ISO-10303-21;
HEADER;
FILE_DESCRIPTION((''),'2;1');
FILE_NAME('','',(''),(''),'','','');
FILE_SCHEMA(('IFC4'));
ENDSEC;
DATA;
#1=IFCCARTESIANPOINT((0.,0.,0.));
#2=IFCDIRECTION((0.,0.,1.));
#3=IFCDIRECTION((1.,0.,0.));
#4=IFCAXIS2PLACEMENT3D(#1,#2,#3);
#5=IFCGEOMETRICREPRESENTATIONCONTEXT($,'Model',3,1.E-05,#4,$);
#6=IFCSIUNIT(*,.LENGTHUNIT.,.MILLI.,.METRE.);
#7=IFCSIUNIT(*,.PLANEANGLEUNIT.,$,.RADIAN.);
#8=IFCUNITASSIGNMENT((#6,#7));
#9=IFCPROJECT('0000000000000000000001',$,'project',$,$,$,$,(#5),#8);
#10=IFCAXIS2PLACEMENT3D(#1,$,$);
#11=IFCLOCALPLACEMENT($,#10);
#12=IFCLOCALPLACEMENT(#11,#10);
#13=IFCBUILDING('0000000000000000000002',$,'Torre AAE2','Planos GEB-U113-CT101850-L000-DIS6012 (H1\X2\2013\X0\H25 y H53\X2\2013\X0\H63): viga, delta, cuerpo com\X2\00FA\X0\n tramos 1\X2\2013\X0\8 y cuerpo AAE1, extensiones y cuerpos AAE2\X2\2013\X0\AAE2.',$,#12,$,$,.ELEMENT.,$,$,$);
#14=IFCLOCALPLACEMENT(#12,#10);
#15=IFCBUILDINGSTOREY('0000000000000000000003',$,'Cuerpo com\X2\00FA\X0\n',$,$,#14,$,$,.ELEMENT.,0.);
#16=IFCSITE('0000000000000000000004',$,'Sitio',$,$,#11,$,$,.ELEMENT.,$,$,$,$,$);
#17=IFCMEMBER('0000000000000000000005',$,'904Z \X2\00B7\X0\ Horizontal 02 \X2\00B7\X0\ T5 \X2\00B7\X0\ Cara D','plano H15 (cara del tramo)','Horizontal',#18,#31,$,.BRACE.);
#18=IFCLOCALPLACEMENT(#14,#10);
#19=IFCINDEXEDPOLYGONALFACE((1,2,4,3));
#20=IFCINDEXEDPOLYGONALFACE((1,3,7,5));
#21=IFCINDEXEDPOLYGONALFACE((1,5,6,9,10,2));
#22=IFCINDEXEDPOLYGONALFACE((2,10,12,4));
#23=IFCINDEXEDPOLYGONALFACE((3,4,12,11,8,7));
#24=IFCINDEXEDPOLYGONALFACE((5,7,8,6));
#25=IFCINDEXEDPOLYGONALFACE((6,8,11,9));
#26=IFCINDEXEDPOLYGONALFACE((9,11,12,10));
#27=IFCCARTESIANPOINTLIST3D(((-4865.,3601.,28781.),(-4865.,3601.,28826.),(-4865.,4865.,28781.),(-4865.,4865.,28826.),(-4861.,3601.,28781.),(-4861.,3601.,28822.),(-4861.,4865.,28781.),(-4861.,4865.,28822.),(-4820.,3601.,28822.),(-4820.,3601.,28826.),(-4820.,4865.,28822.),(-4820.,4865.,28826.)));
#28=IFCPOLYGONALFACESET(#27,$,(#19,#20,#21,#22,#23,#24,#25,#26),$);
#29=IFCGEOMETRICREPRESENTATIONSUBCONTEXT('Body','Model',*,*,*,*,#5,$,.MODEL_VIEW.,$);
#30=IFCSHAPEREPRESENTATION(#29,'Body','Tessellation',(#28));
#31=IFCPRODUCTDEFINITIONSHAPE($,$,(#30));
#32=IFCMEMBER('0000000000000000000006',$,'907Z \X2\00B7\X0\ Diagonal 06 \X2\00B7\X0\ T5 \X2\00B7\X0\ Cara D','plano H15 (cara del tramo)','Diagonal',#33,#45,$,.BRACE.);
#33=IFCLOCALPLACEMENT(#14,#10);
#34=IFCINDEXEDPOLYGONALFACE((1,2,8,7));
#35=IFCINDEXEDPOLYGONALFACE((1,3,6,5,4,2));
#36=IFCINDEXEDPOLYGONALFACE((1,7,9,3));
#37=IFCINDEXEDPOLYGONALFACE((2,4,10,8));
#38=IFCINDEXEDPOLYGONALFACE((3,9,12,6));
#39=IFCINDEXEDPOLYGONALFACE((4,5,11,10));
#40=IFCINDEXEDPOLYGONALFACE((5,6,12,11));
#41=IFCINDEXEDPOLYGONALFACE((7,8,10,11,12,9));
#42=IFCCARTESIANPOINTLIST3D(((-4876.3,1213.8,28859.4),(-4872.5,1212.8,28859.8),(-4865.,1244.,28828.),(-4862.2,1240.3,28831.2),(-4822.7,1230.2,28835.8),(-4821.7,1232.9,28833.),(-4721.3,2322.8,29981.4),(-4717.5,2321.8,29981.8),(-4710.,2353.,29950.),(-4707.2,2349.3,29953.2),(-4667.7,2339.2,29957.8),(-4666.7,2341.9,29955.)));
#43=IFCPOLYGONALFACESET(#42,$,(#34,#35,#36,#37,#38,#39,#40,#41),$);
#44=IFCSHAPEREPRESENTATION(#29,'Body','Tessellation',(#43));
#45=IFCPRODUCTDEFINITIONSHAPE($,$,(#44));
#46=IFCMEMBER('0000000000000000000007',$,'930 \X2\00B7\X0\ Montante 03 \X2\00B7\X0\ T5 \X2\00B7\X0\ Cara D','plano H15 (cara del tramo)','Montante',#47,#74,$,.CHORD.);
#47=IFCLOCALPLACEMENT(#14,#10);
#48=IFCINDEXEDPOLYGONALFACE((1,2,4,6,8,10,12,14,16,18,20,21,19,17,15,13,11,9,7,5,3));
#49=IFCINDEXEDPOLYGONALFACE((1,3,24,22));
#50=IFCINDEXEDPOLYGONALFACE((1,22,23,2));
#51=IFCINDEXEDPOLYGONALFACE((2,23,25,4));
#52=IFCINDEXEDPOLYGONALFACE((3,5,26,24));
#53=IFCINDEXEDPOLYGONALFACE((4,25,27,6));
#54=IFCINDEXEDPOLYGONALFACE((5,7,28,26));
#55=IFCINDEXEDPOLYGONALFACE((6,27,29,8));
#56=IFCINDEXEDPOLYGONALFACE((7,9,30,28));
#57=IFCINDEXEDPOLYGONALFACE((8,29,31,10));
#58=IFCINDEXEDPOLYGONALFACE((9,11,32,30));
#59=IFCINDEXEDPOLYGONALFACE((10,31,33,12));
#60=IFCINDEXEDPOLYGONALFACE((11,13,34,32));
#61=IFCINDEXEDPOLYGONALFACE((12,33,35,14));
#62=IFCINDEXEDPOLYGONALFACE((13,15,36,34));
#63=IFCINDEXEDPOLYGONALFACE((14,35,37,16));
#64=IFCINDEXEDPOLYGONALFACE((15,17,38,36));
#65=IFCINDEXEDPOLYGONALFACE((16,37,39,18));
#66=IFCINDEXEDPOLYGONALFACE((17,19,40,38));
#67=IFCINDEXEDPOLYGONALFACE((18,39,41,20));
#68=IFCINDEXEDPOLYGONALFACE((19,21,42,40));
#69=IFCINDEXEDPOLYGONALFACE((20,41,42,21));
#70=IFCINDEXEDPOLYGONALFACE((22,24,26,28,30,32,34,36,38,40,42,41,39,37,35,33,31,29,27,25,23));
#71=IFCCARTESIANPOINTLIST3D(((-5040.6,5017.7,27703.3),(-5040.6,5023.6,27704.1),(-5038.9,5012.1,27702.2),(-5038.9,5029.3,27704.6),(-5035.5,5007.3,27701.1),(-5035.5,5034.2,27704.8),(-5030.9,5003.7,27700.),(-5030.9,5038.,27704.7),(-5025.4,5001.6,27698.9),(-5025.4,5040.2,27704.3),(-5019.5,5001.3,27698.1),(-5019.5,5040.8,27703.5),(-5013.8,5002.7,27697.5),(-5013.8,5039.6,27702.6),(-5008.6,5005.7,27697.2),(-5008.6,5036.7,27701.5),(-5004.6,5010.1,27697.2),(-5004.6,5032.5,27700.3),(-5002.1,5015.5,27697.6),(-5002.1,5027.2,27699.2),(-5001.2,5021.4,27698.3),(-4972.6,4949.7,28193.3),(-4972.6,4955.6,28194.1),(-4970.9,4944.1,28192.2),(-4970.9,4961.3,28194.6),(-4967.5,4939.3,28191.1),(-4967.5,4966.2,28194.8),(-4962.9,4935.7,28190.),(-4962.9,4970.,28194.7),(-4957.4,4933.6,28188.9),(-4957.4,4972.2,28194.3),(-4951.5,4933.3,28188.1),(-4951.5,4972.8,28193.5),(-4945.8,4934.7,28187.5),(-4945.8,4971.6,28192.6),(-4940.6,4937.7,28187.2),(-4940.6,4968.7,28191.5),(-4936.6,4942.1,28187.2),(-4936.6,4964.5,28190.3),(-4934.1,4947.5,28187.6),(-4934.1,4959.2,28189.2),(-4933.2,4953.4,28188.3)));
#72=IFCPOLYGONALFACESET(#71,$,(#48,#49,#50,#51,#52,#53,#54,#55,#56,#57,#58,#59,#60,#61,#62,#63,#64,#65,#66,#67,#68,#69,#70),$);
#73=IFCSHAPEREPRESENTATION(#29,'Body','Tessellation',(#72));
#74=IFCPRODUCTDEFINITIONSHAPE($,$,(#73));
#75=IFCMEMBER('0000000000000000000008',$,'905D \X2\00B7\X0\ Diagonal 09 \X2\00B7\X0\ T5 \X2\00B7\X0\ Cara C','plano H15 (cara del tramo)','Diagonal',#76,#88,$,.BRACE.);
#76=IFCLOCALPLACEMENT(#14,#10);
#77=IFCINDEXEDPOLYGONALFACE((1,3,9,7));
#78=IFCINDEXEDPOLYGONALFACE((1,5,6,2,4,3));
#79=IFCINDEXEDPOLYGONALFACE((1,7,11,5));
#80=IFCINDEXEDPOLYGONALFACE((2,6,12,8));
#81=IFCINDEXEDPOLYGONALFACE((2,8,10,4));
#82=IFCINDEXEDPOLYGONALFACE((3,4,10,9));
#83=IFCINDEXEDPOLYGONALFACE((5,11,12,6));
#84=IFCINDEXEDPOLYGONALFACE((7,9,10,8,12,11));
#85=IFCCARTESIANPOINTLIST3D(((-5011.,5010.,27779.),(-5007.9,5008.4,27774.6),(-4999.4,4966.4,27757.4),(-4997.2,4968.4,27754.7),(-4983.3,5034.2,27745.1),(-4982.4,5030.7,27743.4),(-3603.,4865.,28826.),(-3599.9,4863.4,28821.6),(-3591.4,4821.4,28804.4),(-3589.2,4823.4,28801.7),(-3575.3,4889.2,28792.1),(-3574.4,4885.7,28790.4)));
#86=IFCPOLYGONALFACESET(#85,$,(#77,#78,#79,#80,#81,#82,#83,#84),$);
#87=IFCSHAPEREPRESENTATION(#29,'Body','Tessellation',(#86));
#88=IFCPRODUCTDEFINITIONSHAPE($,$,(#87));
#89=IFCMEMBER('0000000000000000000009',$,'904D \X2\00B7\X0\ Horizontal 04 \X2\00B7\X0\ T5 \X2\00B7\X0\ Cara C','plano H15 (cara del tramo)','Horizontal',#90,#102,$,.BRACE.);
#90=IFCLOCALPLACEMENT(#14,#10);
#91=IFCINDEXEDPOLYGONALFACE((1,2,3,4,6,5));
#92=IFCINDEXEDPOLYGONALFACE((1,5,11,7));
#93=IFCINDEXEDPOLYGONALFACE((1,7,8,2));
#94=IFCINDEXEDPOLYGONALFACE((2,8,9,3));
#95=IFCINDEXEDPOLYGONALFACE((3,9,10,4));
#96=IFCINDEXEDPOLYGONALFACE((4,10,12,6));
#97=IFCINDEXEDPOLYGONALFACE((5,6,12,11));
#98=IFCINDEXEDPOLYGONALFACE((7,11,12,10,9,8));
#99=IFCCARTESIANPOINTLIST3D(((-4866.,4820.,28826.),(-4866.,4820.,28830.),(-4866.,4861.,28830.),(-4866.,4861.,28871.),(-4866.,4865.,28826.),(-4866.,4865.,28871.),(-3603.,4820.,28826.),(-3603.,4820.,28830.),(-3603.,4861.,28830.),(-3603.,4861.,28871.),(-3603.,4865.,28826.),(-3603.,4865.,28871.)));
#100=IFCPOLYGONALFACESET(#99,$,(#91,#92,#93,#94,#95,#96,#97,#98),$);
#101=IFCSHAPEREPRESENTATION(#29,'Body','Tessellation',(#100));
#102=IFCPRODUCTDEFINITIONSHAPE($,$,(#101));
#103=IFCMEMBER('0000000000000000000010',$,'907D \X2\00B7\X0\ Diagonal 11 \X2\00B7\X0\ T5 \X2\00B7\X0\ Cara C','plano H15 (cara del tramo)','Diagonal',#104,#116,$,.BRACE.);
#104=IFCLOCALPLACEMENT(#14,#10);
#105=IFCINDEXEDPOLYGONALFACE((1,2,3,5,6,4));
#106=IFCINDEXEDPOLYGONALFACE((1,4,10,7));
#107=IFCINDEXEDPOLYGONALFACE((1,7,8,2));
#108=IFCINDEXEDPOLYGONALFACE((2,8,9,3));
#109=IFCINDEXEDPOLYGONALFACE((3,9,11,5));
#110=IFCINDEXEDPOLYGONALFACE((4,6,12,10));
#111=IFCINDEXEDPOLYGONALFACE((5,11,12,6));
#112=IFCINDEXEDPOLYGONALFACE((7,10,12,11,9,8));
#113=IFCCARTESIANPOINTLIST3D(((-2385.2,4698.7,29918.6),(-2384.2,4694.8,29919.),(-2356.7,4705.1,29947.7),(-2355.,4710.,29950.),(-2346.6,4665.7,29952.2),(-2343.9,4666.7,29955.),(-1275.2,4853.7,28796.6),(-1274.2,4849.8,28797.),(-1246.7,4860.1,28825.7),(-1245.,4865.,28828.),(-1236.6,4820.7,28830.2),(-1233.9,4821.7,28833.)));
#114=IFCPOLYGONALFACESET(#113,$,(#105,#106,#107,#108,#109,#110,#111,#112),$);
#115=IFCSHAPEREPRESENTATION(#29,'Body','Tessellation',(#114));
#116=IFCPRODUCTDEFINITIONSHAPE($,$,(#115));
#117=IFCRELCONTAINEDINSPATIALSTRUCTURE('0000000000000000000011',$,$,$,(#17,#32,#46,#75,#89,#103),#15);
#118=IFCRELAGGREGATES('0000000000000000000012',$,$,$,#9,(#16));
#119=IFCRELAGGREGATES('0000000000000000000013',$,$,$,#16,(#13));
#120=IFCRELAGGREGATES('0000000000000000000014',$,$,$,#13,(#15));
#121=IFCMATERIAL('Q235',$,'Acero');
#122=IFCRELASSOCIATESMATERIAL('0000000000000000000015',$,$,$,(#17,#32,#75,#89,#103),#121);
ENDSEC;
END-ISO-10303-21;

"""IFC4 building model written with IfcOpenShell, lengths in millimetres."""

from ifc_helpers import new_model, si_unit, frame, frame_2d, origin, origin_with_axes, place, context, subcontext, project, spatial, circle, l_section, extrude, material, element, save


model = new_model("IFC4")

# Units and contexts
model_context = context("Model", 3, precision=1e-05, world=origin_with_axes())
body_context = subcontext(model_context, "Body", "Model", "MODEL_VIEW")
ifc_project = project(units=[si_unit("LENGTHUNIT", "METRE", prefix="MILLI"), si_unit("PLANEANGLEUNIT", "RADIAN")], contexts=[model_context])

# Site, building, storey
site_placement = place(None, origin())
site = spatial("IfcSite", under=ifc_project, at=site_placement, Name="Sitio", CompositionType="ELEMENT")
building_placement = place(site_placement, origin())
building = spatial("IfcBuilding", under=site, at=building_placement, Name="Torre AAE2", Description="Planos GEB-U113-CT101850-L000-DIS6012 (H1–H25 y H53–H63): viga, delta, cuerpo común tramos 1–8 y cuerpo AAE1, extensiones y cuerpos AAE2–AAE2.", CompositionType="ELEMENT")
storey_placement = place(building_placement, origin())
storey = spatial("IfcBuildingStorey", under=building, at=storey_placement, Name="Cuerpo común", CompositionType="ELEMENT", Elevation=0.0)

# Members
ifc_material_1 = material(Name="Q235", Category="Acero")
member_1_placement = place(storey_placement, frame((-4865.0, 3601.0, 28826.0), z_axis=(0.0, 1.0, 0.0), x_axis=(1.0, 0.0, 0.0)))
element("IfcMember", 1, at=member_1_placement, inside=storey, material=ifc_material_1, Name="904Z · Horizontal 02 · T5 · Cara D", Description="plano H15 (cara del tramo)", ObjectType="Horizontal", PredefinedType="BRACE", context=body_context, shape_type="SweptSolid", body=[
    extrude(l_section(Depth=45.0, Width=45.0, Thickness=4.0, at=frame_2d((22.5, 22.5))), None, (0.0, 0.0, 1.0), 1264.0),
])
member_2_placement = place(storey_placement, frame((-4710.0, 2353.0, 29950.0), z_axis=(-0.097781, -0.699606, -0.707807), x_axis=(0.962791, -0.246544, 0.110682)))
element("IfcMember", 2, at=member_2_placement, inside=storey, material=ifc_material_1, Name="907Z · Diagonal 06 · T5 · Cara D", Description="plano H15 (cara del tramo)", ObjectType="Diagonal", PredefinedType="BRACE", context=body_context, shape_type="SweptSolid", body=[
    extrude(l_section(Depth=45.0, Width=45.0, Thickness=4.0, at=frame_2d((22.5, 22.5))), None, (0.0, 0.0, 1.0), 1585.2),
])
member_3_placement = place(storey_placement, frame((-4953.0, 4953.0, 28191.0), z_axis=(-0.136178, 0.136178, -0.98128), x_axis=(0.990684, 0.018719, -0.134885)))
element("IfcMember", 3, at=member_3_placement, inside=storey, Name="930 · Montante 03 · T5 · Cara D", Description="plano H15 (cara del tramo)", ObjectType="Montante", PredefinedType="CHORD", context=body_context, shape_type="SweptSolid", body=[
    extrude(circle(Radius=20.0), None, (0.0, 0.0, 1.0), 499.3),
])
member_4_placement = place(storey_placement, frame((-5011.0, 5010.0, 27779.0), z_axis=(0.799729, -0.082358, 0.594685), x_axis=(0.231509, -0.871631, -0.432045)))
element("IfcMember", 4, at=member_4_placement, inside=storey, material=ifc_material_1, Name="905D · Diagonal 09 · T5 · Cara C", Description="plano H15 (cara del tramo)", ObjectType="Diagonal", PredefinedType="BRACE", context=body_context, shape_type="SweptSolid", body=[
    extrude(l_section(Depth=50.0, Width=50.0, Thickness=4.0, at=frame_2d((25.0, 25.0))), None, (0.0, 0.0, 1.0), 1760.6),
])
member_5_placement = place(storey_placement, frame((-3603.0, 4865.0, 28826.0), z_axis=(-1.0, 0.0, 0.0), x_axis=(0.0, -1.0, 0.0)))
element("IfcMember", 5, at=member_5_placement, inside=storey, material=ifc_material_1, Name="904D · Horizontal 04 · T5 · Cara C", Description="plano H15 (cara del tramo)", ObjectType="Horizontal", PredefinedType="BRACE", context=body_context, shape_type="SweptSolid", body=[
    extrude(l_section(Depth=45.0, Width=45.0, Thickness=4.0, at=frame_2d((22.5, 22.5))), None, (0.0, 0.0, 1.0), 1263.0),
])
member_6_placement = place(storey_placement, frame((-2355.0, 4710.0, 29950.0), z_axis=(0.699928, 0.097738, -0.707495), x_axis=(0.246524, -0.962772, 0.110884)))
element("IfcMember", 6, at=member_6_placement, inside=storey, material=ifc_material_1, Name="907D · Diagonal 11 · T5 · Cara C", Description="plano H15 (cara del tramo)", ObjectType="Diagonal", PredefinedType="BRACE", context=body_context, shape_type="SweptSolid", body=[
    extrude(l_section(Depth=45.0, Width=45.0, Thickness=4.0, at=frame_2d((22.5, 22.5))), None, (0.0, 0.0, 1.0), 1585.9),
])

save(model, "model.ifc")
